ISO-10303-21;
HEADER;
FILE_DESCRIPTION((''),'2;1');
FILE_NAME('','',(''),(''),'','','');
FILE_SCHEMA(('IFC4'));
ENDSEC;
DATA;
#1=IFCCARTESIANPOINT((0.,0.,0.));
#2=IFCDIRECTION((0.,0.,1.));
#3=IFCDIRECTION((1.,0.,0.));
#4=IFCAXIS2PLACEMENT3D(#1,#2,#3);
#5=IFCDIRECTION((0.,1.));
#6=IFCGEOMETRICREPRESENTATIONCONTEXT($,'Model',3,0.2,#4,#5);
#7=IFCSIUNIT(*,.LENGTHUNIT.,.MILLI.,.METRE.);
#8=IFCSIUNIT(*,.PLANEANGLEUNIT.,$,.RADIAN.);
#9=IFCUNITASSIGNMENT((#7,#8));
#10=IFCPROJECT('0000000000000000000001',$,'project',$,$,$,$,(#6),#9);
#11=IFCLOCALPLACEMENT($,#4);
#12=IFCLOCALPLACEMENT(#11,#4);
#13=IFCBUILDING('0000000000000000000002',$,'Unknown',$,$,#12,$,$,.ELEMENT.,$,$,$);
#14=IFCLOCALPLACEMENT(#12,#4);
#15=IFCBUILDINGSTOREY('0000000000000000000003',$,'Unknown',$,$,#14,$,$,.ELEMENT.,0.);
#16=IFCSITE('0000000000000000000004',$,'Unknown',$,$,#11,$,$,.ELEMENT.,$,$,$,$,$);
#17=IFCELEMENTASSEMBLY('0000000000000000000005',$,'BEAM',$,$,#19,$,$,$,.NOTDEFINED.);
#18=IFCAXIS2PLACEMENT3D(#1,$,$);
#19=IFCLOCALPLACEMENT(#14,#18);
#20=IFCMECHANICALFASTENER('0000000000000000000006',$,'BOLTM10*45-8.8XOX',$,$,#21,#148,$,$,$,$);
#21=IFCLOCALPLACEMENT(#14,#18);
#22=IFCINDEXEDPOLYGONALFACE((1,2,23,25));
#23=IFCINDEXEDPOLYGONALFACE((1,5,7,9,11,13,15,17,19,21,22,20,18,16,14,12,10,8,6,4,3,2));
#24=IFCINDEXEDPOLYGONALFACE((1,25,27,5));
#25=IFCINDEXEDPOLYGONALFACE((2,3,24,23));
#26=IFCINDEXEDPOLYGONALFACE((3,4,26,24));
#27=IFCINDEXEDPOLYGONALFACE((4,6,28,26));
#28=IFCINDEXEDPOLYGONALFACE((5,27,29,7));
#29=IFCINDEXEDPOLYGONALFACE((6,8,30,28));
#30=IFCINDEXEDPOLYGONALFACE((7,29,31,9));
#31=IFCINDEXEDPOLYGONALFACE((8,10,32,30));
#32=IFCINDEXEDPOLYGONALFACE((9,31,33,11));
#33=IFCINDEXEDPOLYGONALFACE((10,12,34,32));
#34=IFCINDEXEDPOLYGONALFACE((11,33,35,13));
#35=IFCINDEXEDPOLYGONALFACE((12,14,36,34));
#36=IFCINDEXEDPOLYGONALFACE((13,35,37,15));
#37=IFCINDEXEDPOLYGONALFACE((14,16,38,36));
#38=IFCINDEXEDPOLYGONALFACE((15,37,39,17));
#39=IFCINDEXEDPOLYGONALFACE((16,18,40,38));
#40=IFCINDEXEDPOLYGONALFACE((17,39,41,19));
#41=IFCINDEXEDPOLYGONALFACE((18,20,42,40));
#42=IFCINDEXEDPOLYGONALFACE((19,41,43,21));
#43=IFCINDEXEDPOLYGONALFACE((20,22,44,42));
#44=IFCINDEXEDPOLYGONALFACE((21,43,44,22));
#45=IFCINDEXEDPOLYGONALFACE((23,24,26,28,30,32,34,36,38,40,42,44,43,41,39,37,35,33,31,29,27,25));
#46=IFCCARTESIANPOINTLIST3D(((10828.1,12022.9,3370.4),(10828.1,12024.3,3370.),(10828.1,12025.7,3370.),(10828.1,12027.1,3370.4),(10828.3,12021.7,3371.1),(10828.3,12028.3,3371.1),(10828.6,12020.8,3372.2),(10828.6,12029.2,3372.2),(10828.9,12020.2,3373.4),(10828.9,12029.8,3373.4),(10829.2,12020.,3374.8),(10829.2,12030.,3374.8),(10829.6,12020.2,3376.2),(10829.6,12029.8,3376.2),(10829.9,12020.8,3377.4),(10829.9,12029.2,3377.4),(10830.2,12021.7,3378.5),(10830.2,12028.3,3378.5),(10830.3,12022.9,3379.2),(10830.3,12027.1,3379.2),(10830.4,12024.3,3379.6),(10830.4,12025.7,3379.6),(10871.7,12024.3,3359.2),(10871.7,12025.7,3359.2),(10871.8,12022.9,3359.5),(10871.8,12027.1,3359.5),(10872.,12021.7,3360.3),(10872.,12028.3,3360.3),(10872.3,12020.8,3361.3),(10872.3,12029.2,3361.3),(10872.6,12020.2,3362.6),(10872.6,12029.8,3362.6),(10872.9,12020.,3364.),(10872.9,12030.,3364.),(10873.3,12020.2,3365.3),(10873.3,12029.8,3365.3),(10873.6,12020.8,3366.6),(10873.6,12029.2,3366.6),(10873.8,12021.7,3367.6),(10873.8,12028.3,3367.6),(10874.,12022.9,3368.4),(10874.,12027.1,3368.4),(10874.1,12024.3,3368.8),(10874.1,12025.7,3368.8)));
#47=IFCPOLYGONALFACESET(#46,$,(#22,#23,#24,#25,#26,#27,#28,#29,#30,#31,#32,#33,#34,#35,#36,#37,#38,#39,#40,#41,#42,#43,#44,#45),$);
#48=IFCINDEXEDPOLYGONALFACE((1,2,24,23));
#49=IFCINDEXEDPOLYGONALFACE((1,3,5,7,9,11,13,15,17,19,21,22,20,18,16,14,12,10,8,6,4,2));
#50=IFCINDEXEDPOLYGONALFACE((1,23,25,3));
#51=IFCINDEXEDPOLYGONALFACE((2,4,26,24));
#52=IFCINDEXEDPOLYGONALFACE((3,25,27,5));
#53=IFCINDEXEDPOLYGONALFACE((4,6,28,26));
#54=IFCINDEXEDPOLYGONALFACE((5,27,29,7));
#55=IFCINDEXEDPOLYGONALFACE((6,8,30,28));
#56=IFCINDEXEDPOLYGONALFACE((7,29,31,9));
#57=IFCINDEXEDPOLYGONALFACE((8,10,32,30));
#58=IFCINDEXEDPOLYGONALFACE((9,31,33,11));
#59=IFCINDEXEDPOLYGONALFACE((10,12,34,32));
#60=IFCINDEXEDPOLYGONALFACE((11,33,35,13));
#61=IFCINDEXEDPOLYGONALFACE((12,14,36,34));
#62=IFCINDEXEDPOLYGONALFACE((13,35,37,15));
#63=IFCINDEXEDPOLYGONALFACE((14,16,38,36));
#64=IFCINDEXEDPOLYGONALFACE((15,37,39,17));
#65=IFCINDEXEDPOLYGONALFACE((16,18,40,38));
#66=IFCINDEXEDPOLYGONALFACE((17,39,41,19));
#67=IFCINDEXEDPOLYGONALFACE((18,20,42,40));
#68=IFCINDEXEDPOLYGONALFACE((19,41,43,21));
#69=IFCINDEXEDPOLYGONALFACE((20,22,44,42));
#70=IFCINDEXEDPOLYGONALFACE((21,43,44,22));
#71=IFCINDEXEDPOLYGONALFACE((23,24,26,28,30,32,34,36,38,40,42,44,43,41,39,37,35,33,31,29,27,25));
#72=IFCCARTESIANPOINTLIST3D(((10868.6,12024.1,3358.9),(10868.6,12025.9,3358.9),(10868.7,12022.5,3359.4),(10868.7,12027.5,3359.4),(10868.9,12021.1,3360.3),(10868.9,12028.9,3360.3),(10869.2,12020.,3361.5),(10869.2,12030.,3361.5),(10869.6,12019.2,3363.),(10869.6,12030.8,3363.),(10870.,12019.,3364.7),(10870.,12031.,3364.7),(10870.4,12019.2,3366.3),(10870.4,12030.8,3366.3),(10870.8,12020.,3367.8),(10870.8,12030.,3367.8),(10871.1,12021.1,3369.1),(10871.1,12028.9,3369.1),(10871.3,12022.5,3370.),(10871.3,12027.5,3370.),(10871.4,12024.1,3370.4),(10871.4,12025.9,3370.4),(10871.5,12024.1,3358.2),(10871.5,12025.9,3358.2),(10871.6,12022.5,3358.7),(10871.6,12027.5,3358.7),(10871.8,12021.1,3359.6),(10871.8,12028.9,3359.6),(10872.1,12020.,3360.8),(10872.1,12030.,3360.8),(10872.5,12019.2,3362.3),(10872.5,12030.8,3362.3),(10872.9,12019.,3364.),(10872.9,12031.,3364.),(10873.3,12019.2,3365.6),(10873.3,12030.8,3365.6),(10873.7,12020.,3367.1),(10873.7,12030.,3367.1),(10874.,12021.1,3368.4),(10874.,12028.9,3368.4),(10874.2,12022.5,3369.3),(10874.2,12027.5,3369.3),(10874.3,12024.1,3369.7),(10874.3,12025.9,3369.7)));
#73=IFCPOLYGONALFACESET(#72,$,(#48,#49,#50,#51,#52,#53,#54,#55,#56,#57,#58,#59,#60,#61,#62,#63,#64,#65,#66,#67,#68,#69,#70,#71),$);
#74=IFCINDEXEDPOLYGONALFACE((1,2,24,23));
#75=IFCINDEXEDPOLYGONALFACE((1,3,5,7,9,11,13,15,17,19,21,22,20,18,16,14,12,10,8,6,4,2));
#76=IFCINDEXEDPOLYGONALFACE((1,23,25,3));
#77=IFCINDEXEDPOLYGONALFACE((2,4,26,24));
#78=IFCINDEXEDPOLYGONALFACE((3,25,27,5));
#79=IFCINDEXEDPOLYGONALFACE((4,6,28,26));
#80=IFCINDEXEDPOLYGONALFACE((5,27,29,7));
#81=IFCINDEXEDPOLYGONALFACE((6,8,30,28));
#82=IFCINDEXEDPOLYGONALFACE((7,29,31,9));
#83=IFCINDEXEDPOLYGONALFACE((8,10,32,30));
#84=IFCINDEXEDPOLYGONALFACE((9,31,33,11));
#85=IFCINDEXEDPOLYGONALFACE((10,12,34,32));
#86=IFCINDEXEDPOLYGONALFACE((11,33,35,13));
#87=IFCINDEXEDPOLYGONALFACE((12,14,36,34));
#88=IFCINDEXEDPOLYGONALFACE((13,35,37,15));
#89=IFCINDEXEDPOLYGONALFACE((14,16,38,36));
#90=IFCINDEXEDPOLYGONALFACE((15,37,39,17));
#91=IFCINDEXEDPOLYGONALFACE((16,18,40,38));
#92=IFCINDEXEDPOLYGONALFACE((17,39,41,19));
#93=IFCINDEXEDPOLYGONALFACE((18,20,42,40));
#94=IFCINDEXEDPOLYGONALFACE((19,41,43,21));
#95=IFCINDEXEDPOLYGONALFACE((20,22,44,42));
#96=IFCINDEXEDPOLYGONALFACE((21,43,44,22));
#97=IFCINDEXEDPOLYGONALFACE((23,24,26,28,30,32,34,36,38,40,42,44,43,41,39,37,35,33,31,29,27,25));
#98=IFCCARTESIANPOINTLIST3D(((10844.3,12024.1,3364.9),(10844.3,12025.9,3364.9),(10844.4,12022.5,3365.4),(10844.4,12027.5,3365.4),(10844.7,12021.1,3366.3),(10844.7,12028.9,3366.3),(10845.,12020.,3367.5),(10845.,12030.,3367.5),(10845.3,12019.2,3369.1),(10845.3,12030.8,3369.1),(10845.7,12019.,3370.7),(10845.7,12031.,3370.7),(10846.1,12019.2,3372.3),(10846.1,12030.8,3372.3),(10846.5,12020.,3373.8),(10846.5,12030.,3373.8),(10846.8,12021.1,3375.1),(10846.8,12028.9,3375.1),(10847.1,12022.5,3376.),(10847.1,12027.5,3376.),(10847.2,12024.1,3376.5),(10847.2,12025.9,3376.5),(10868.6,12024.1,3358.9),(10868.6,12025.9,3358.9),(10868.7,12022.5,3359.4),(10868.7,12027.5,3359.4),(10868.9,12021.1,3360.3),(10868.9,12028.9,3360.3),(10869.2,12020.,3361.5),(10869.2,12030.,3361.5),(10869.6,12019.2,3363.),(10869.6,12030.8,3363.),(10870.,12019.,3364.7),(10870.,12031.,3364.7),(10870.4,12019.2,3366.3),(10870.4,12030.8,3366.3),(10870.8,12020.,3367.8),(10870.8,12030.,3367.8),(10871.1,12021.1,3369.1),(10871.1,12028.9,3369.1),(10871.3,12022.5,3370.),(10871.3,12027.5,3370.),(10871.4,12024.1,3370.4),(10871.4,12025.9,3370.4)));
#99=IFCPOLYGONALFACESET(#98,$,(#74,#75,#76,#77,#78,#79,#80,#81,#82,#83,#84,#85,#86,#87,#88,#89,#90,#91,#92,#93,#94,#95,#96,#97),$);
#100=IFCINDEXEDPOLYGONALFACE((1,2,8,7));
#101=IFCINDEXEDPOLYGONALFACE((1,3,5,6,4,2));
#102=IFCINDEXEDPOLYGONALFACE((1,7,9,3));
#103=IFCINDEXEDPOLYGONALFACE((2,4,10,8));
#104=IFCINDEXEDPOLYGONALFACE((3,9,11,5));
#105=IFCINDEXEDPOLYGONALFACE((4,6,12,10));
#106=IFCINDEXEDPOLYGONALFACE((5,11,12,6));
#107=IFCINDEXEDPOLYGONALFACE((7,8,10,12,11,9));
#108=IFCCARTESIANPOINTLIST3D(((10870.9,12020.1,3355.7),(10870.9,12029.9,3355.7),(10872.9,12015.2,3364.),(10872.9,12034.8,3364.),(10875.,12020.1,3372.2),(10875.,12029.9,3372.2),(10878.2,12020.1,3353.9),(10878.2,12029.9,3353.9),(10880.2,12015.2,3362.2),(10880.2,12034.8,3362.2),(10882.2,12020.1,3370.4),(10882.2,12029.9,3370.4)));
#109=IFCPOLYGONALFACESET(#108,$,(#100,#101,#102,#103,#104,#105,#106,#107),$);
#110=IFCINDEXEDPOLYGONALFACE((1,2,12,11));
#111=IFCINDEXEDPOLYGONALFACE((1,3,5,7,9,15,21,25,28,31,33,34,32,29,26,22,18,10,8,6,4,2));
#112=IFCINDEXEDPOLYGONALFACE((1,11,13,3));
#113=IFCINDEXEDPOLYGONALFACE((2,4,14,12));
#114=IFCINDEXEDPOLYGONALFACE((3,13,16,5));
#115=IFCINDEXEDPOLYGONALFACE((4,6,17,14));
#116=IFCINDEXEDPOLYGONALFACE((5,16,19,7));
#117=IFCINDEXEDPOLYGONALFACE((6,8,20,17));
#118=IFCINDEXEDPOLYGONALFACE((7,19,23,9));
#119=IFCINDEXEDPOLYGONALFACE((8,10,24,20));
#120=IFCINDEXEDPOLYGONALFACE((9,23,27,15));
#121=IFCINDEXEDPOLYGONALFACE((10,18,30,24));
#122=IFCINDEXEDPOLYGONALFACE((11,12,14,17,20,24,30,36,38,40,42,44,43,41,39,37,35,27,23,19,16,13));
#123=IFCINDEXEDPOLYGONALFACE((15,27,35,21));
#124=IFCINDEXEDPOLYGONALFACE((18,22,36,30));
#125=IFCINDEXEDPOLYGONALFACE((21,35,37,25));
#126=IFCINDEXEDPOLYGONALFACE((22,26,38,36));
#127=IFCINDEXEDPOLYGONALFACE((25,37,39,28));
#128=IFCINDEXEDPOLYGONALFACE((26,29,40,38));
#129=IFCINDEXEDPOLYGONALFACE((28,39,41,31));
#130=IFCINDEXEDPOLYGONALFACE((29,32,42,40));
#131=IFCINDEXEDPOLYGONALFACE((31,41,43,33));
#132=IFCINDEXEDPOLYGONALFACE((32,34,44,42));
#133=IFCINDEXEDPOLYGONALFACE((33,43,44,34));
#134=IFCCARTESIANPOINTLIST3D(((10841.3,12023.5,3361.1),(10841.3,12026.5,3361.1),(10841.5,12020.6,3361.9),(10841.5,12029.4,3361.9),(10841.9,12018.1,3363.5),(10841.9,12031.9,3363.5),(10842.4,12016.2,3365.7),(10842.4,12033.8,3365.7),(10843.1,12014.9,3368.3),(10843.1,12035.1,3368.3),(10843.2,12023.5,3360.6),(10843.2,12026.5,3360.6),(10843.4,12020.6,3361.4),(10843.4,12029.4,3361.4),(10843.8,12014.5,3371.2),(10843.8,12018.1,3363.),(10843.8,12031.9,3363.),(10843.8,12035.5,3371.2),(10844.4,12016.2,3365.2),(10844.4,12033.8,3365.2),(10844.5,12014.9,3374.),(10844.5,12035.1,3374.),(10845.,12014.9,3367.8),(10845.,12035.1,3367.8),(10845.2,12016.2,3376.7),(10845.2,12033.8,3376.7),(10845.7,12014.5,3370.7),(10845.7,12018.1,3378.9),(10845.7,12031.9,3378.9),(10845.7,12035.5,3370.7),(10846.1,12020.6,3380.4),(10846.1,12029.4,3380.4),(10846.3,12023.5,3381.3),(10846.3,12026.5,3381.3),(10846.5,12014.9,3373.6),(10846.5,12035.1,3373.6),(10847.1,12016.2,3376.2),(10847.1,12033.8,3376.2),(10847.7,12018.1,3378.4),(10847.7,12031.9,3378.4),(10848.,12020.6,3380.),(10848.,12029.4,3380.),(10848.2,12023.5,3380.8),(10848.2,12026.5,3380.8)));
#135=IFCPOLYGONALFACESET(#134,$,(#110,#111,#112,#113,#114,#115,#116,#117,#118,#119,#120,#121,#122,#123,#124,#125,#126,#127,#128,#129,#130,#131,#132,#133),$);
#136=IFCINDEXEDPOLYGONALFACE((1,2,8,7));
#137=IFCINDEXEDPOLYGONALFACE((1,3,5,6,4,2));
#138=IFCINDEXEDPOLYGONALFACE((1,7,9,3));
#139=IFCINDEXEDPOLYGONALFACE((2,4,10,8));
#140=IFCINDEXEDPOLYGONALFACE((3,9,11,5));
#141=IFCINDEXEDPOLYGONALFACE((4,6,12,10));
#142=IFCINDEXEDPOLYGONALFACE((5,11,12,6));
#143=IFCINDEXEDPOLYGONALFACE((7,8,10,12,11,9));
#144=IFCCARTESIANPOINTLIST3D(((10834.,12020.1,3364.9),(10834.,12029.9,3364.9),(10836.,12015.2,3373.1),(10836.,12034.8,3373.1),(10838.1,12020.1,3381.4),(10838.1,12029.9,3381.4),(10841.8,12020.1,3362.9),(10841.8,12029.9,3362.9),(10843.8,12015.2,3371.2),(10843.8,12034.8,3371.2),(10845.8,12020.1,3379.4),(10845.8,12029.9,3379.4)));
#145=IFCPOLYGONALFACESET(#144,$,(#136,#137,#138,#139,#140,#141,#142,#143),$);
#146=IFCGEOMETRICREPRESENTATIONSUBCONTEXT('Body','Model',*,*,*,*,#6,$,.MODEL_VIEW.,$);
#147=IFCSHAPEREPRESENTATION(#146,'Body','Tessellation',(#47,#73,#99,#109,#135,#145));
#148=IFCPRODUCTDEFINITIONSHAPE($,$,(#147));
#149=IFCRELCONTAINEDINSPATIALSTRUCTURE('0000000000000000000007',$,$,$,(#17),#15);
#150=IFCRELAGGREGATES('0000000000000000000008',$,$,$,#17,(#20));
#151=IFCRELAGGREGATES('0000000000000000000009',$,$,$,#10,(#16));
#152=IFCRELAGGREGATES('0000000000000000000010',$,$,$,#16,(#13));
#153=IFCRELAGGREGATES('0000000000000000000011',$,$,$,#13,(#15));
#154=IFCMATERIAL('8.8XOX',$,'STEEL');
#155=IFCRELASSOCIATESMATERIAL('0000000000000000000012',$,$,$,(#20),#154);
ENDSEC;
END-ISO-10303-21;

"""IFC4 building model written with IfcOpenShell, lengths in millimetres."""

from ifc_helpers import new_model, si_unit, direction, frame, origin_with_axes, place, context, subcontext, project, spatial, line, arc, indexed_curve, outline, extrude, source, transform, mapped, material, element, aggregate, save


model = new_model("IFC4")

# Units and contexts
model_context = context("Model", 3, precision=0.2, world=origin_with_axes(), true_north=direction((0.0, 1.0)))
body_context = subcontext(model_context, "Body", "Model", "MODEL_VIEW")
ifc_project = project(units=[si_unit("LENGTHUNIT", "METRE", prefix="MILLI"), si_unit("PLANEANGLEUNIT", "RADIAN")], contexts=[model_context])

# Site, building, storey
site_placement = place(None, origin_with_axes())
site = spatial("IfcSite", under=ifc_project, at=site_placement, Name="Unknown", CompositionType="ELEMENT")
building_placement = place(site_placement, origin_with_axes())
building = spatial("IfcBuilding", under=site, at=building_placement, Name="Unknown", CompositionType="ELEMENT")
storey_placement = place(building_placement, origin_with_axes())
storey = spatial("IfcBuildingStorey", under=building, at=storey_placement, Name="Unknown", CompositionType="ELEMENT", Elevation=0.0)

# Shared definitions
ifc_material_1 = material(Name="8.8XOX", Category="STEEL")

# Element assembly, mechanical fastener
assembly_1_placement = place(storey_placement, frame((10859.1, 12000.0, 3372.5), z_axis=(0.970613, 0.0, -0.240648), x_axis=(0.0, 1.0, 0.0)))
assembly_1 = element("IfcElementAssembly", 1, at=assembly_1_placement, inside=storey, Name="BEAM", PredefinedType="NOTDEFINED")
shared_shape_1 = source(origin_with_axes(), body_context, "Body", "SweptSolid", [
    extrude(outline(indexed_curve([(5.0, 0.0), (0.0, 5.0), (-5.0, 0.0), (0.0, -5.0)], segments=[arc(1, 2, 3), arc(3, 4, 1)])), frame((0.0, 0.0, 3.8), z_axis=(0.0, 0.0, -1.0), x_axis=(0.0, 1.0, 0.0)), (0.0, 0.0, 1.0), 45.0),
    extrude(outline(indexed_curve([(6.0, 0.0), (0.0, 6.0), (-6.0, 0.0), (0.0, -6.0)], segments=[arc(1, 2, 3), arc(3, 4, 1)])), frame((0.0, 0.0, 3.8), z_axis=(0.0, 0.0, -1.0), x_axis=(0.0, 1.0, 0.0)), (0.0, 0.0, 1.0), 3.0),
    extrude(outline(indexed_curve([(6.0, 0.0), (0.0, 6.0), (-6.0, 0.0), (0.0, -6.0)], segments=[arc(1, 2, 3), arc(3, 4, 1)])), frame((0.0, 0.0, 0.8), z_axis=(0.0, 0.0, -1.0), x_axis=(0.0, 1.0, 0.0)), (0.0, 0.0, 1.0), 25.0),
    extrude(outline(indexed_curve([(9.8, 0.0), (4.9, 8.5), (-4.9, 8.5), (-9.8, 0.0), (-4.9, -8.5), (4.9, -8.5)], segments=[line(1, 2, 3, 4, 5, 6, 1)])), frame((0.0, 0.0, 11.2), z_axis=(0.0, 0.0, -1.0), x_axis=(0.0, 1.0, 0.0)), (0.0, 0.0, 1.0), 7.5),
    extrude(outline(indexed_curve([(10.5, 0.0), (0.0, 10.5), (-10.5, 0.0), (0.0, -10.5)], segments=[arc(1, 2, 3), arc(3, 4, 1)])), frame((0.0, 0.0, -24.2), z_axis=(0.0, 0.0, -1.0), x_axis=(0.0, 1.0, 0.0)), (0.0, 0.0, 1.0), 2.0),
    extrude(outline(indexed_curve([(9.8, 0.0), (4.9, 8.5), (-4.9, 8.5), (-9.8, 0.0), (-4.9, -8.5), (4.9, -8.5)], segments=[line(1, 2, 3, 4, 5, 6, 1)])), frame((0.0, 0.0, -26.2), z_axis=(0.0, 0.0, -1.0), x_axis=(0.0, 1.0, 0.0)), (0.0, 0.0, 1.0), 8.0),
])
mechanical_fastener_1_placement = place(assembly_1_placement, frame((25.0, -5.0, 11.8), z_axis=(0.0, 0.0, 1.0), x_axis=(0.0, 1.0, 0.0)))
mechanical_fastener_1 = element("IfcMechanicalFastener", 2, at=mechanical_fastener_1_placement, material=ifc_material_1, Name="BOLTM10*45-8.8XOX", context=body_context, shape_type="MappedRepresentation", body=[
    mapped(shared_shape_1, transform((0.0, 0.0, 0.0))),
])
aggregate(assembly_1, [mechanical_fastener_1])

save(model, "model.ifc")
